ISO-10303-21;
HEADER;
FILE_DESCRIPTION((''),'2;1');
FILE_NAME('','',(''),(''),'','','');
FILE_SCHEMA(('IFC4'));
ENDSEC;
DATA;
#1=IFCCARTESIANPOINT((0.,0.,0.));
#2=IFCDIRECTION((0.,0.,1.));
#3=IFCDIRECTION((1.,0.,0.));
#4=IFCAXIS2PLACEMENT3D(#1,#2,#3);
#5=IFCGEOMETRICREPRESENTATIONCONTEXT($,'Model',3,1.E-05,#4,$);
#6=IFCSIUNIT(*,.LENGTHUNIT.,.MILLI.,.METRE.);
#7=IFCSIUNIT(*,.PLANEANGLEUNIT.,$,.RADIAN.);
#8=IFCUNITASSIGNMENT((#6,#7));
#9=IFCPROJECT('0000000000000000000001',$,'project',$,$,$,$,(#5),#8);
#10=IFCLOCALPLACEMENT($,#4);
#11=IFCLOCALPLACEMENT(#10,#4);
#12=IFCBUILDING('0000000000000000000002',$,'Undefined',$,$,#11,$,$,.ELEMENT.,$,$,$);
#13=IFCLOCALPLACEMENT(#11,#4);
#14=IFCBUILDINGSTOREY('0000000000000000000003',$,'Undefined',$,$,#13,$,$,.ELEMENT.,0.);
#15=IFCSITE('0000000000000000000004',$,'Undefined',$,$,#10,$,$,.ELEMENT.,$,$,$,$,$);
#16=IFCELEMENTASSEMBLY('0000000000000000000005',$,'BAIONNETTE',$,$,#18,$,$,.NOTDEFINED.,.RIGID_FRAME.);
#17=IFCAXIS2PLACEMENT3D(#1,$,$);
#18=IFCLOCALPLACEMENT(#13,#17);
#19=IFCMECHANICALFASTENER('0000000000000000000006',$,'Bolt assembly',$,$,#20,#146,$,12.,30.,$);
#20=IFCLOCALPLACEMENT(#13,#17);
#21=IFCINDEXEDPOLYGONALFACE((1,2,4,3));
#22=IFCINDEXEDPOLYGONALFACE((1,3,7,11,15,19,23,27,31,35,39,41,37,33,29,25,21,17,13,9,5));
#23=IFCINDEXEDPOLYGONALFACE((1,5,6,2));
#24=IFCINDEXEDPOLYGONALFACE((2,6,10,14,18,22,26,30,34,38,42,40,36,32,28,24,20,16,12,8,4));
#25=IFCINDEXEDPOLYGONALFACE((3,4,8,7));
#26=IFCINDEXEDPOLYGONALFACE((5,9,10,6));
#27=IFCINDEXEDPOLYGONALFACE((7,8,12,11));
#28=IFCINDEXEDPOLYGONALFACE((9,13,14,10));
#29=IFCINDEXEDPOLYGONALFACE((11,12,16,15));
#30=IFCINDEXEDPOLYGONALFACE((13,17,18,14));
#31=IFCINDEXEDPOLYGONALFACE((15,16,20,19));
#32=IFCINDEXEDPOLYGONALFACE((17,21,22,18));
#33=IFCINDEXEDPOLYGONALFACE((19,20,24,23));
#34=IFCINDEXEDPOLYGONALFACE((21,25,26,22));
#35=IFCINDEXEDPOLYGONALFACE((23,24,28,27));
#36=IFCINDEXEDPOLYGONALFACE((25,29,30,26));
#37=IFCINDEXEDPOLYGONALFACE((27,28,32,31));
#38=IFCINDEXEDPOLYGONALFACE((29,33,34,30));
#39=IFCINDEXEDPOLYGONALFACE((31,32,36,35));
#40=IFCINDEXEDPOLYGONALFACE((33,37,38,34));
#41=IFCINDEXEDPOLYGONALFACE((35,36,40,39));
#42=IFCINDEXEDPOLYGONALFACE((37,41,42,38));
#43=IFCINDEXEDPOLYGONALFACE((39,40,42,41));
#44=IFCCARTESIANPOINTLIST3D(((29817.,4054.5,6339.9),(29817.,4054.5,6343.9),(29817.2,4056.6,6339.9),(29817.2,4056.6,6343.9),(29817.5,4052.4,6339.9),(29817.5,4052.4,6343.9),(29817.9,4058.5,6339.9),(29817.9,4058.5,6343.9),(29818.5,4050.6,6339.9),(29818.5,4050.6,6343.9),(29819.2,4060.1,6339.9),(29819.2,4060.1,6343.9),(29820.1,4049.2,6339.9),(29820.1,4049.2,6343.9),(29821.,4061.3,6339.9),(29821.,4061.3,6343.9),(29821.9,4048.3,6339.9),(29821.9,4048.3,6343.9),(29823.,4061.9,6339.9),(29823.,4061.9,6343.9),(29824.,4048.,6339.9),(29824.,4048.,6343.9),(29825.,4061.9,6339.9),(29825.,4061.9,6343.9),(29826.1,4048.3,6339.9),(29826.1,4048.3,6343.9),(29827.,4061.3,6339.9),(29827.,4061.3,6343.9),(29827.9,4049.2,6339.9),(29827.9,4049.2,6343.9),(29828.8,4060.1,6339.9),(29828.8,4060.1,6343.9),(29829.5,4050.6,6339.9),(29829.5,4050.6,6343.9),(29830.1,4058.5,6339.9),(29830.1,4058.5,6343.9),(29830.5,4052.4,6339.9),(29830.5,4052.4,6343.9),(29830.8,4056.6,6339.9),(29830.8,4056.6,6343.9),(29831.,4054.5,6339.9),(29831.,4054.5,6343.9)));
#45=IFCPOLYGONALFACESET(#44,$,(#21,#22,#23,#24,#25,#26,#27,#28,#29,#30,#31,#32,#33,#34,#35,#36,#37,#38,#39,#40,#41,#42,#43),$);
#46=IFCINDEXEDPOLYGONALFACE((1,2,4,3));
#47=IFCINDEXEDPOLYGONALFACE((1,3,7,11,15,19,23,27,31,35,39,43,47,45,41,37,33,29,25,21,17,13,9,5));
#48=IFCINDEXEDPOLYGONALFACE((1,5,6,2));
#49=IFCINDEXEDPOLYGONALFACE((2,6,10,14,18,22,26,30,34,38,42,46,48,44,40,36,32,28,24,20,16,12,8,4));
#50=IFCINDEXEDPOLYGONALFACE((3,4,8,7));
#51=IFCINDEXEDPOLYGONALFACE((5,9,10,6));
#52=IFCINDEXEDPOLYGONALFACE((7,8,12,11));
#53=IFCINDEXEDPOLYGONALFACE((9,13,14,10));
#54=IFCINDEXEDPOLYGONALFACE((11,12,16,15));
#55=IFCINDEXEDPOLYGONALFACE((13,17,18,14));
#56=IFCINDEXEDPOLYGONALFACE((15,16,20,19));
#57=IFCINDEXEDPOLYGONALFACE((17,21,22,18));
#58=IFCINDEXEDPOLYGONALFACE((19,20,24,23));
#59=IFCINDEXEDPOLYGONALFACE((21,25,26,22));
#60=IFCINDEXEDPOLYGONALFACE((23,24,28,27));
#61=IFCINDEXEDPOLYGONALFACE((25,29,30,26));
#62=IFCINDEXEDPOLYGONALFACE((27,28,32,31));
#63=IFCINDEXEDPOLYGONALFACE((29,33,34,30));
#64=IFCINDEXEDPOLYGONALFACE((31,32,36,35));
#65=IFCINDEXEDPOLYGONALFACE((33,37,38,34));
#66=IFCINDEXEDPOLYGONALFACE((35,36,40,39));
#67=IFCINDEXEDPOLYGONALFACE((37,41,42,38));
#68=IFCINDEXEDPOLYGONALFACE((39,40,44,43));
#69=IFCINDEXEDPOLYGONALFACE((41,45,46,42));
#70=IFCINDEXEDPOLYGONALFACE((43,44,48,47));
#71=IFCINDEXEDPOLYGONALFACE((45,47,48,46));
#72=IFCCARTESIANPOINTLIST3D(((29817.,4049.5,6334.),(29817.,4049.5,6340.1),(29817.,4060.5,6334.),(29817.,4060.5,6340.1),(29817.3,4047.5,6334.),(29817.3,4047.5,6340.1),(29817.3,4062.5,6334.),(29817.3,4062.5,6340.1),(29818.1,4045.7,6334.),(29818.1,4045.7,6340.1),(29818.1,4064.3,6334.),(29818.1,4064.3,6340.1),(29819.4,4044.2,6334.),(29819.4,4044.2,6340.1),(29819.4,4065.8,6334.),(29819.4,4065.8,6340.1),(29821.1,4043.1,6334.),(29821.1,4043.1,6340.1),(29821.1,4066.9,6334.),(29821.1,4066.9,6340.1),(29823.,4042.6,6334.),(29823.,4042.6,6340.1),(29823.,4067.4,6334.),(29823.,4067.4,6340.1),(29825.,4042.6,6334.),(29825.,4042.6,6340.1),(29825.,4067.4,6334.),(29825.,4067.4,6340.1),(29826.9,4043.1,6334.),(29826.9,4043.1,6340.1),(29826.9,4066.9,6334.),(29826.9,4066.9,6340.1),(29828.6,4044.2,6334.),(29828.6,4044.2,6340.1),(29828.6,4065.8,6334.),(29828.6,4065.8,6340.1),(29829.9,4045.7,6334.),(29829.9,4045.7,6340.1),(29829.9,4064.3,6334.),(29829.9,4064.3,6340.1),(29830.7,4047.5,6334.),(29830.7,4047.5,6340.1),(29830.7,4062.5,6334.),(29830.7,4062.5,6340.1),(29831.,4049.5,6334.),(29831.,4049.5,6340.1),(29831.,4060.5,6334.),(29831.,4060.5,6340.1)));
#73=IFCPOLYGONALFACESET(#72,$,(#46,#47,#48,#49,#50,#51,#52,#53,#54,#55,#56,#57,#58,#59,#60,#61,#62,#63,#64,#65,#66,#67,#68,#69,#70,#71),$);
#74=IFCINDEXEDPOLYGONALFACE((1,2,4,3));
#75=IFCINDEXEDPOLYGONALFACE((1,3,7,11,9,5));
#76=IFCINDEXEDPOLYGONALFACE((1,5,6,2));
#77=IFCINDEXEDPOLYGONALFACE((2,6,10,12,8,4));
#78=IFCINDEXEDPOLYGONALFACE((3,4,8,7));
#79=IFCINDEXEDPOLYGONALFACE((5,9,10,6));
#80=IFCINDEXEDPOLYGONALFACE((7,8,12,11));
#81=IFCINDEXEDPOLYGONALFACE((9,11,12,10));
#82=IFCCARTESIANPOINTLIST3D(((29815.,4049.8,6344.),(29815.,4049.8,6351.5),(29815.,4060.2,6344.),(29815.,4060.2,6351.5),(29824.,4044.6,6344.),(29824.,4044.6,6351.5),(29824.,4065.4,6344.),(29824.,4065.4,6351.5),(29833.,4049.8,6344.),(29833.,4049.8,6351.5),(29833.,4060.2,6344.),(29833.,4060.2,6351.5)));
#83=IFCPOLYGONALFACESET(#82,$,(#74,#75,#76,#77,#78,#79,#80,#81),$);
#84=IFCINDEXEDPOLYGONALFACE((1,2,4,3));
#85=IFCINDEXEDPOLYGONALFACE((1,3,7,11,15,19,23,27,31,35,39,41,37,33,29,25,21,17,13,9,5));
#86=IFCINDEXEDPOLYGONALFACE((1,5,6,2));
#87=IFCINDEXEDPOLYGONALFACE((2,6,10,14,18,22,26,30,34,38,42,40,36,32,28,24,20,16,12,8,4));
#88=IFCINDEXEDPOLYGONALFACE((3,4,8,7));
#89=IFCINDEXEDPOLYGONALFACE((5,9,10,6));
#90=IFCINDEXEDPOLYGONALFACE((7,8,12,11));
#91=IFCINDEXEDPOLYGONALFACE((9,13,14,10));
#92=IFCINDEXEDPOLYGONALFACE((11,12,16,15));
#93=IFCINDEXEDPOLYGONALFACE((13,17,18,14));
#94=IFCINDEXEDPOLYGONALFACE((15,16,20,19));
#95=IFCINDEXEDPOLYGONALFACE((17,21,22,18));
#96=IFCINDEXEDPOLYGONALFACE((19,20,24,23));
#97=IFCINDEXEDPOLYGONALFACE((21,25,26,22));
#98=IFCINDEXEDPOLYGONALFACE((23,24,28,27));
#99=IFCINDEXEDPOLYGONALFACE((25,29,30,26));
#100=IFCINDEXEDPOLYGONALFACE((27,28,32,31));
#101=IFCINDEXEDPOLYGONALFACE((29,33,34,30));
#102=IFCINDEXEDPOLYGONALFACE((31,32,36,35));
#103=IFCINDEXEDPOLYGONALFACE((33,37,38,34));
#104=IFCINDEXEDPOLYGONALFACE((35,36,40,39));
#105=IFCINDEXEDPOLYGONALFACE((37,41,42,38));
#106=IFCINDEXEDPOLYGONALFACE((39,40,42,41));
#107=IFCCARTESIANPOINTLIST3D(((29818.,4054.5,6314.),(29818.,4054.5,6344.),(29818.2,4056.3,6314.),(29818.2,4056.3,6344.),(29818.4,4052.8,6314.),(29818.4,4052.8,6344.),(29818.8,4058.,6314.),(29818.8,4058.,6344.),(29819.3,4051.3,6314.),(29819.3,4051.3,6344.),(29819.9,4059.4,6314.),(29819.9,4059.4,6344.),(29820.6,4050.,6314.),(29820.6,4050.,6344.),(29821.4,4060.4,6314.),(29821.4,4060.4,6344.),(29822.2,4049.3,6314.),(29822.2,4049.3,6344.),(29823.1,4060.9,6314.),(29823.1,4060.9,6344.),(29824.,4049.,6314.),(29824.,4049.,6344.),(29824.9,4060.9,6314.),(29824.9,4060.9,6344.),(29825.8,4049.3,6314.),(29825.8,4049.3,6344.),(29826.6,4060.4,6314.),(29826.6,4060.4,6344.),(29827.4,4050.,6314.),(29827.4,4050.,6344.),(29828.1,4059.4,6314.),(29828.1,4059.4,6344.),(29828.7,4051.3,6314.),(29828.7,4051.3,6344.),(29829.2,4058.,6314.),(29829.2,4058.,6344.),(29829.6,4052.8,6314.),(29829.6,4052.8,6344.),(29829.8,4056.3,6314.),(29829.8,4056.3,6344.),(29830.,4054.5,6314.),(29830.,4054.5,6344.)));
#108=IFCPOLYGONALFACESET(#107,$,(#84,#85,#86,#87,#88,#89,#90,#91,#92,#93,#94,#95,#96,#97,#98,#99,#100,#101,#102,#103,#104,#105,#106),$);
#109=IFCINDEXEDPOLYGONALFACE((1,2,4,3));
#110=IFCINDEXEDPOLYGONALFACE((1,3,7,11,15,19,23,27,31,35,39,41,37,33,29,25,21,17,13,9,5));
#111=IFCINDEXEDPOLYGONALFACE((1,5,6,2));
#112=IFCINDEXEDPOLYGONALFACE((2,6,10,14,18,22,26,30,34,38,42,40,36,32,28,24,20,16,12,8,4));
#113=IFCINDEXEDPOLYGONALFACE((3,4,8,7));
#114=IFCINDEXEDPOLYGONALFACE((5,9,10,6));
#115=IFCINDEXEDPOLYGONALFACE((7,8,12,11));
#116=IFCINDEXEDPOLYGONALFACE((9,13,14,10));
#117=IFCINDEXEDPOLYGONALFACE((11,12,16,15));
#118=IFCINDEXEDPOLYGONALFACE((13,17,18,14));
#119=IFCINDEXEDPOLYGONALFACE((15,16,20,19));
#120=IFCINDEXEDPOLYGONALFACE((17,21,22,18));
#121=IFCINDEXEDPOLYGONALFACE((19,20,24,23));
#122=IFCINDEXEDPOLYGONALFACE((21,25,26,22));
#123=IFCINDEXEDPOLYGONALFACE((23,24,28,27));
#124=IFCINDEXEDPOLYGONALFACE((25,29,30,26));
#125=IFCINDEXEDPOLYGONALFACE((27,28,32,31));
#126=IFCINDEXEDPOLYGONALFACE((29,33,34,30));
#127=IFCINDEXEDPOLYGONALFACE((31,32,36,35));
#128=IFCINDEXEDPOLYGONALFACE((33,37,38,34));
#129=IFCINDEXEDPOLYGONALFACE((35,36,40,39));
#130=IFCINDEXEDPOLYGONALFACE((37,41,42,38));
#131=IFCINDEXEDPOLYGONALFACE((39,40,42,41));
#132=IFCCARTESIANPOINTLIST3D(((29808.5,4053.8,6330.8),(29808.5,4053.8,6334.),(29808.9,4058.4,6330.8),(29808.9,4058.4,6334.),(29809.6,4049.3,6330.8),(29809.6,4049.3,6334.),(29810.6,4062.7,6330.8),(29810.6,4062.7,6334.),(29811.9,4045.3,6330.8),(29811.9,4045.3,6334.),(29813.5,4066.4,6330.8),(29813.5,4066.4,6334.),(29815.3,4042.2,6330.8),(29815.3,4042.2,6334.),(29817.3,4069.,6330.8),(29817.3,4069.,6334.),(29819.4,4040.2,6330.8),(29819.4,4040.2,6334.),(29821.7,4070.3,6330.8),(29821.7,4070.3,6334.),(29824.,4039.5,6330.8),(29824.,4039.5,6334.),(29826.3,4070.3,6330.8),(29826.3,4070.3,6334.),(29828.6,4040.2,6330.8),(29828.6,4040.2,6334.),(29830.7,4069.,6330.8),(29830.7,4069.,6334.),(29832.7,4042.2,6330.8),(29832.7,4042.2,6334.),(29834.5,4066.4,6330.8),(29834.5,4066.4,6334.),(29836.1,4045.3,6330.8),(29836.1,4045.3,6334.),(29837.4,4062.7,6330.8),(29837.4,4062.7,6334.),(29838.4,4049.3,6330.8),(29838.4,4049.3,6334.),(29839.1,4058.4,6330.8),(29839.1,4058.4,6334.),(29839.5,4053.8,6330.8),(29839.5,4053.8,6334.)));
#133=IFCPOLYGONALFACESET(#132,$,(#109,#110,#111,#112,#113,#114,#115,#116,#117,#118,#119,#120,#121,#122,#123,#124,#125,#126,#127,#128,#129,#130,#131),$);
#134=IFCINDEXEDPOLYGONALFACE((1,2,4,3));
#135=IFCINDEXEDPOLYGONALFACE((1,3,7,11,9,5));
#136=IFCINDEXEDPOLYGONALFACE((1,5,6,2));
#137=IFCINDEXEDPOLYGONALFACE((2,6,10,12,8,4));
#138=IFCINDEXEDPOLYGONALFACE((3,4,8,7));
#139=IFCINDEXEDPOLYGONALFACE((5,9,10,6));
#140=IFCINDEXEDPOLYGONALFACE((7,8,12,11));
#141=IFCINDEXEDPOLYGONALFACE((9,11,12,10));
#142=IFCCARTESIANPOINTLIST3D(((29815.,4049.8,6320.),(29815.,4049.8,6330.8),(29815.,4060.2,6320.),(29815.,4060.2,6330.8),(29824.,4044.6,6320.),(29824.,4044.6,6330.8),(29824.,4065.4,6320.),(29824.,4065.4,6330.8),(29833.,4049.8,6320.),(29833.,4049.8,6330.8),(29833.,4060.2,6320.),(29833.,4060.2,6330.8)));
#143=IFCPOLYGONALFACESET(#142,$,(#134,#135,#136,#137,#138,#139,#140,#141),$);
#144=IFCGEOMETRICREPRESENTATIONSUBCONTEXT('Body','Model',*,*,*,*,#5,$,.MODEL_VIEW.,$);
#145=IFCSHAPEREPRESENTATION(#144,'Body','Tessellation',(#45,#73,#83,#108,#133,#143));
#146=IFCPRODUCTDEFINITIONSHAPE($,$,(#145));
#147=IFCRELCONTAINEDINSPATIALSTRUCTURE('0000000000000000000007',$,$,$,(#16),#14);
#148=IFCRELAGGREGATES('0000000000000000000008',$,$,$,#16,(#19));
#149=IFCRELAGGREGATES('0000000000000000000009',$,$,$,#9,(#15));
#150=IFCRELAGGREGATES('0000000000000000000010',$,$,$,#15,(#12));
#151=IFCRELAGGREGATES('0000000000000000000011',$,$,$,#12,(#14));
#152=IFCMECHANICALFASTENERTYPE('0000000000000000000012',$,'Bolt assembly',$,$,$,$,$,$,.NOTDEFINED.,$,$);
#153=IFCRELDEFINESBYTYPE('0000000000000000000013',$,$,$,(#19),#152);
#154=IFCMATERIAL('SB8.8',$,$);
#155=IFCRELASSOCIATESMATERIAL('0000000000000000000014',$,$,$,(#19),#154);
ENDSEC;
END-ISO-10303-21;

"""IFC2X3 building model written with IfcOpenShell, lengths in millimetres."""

from ifc_helpers import new_model, si_unit, frame, frame_2d, origin_with_axes, origin_2d_with_axis, place, context, subcontext, project, spatial, polyline, circle_curve, parameter, trimmed, segment, composite_curve, circle, outline, extrude, source, transform, mapped, material, type_object, element, aggregate, save


model = new_model("IFC2X3")

# Units and contexts
model_context = context("Model", 3, precision=1e-05, world=origin_with_axes())
body_context = subcontext(model_context, "Body", "Model", "MODEL_VIEW")
ifc_project = project(units=[si_unit("LENGTHUNIT", "METRE", prefix="MILLI"), si_unit("PLANEANGLEUNIT", "RADIAN")], contexts=[model_context])

# Site, building, storey
site_placement = place(None, origin_with_axes())
site = spatial("IfcSite", under=ifc_project, at=site_placement, Name="Undefined", CompositionType="ELEMENT")
building_placement = place(site_placement, origin_with_axes())
building = spatial("IfcBuilding", under=site, at=building_placement, Name="Undefined", CompositionType="ELEMENT")
storey_placement = place(building_placement, origin_with_axes())
storey = spatial("IfcBuildingStorey", under=building, at=storey_placement, Name="Undefined", CompositionType="ELEMENT", Elevation=0.0)

# Element assembly
assembly_1_placement = place(storey_placement, origin_with_axes())
assembly_1 = element("IfcElementAssembly", 1, at=assembly_1_placement, inside=storey, Name="BAIONNETTE", AssemblyPlace="NOTDEFINED", PredefinedType="RIGID_FRAME")

# Shared definitions
ifc_material_1 = material(Name="SB8.8")
mechanical_fastener_type = type_object("IfcMechanicalFastenerType", Name="Bolt assembly")

# Mechanical fastener
shared_shape_1 = source(origin_with_axes(), body_context, "Body", "SweptSolid", [
    extrude(circle(Radius=7.0, at=origin_2d_with_axis()), frame((0.0, -3.9, 0.0), z_axis=(0.0, 1.0, 0.0), x_axis=(1.0, 0.0, 0.0)), (0.0, 0.0, 1.0), 4.0),
    extrude(outline(composite_curve([segment(polyline([(-5.5, 7.0), (5.5, 7.0)]), True, "CONTINUOUS"), segment(trimmed(circle_curve(frame_2d((5.5, 0.0), x_axis=(0.0, 1.0)), 7.0), [parameter(0.0)], [parameter(3.141593)], False, "PARAMETER"), True, "CONTINUOUS"), segment(polyline([(5.5, -7.0), (-5.5, -7.0)]), True, "CONTINUOUS"), segment(trimmed(circle_curve(frame_2d((-5.5, 0.0), x_axis=(0.0, -1.0)), 7.0), [parameter(0.0)], [parameter(3.141593)], False, "PARAMETER"), True, "DISCONTINUOUS")], self_intersect=False)), frame((0.0, -0.1, 0.0), z_axis=(0.0, 1.0, 0.0), x_axis=(1.0, 0.0, 0.0)), (0.0, 0.0, 1.0), 6.1),
    extrude(outline(polyline([(10.4, 0.0), (5.2, 9.0), (-5.2, 9.0), (-10.4, 0.0), (-5.2, -9.0), (5.2, -9.0), (10.4, 0.0)])), frame((0.0, -11.5, 0.0), z_axis=(0.0, 1.0, 0.0), x_axis=(1.0, 0.0, 0.0)), (0.0, 0.0, 1.0), 7.5),
    extrude(circle(Radius=6.0, at=origin_2d_with_axis()), frame((0.0, -4.0, 0.0), z_axis=(0.0, 1.0, 0.0), x_axis=(1.0, 0.0, 0.0)), (0.0, 0.0, 1.0), 30.0),
    extrude(circle(Radius=15.5, at=origin_2d_with_axis()), frame((0.0, 6.0, 0.0), z_axis=(0.0, 1.0, 0.0), x_axis=(1.0, 0.0, 0.0)), (0.0, 0.0, 1.0), 3.2),
    extrude(outline(polyline([(10.4, 0.0), (5.2, 9.0), (-5.2, 9.0), (-10.4, 0.0), (-5.2, -9.0), (5.2, -9.0), (10.4, 0.0)])), frame((0.0, 9.2, 0.0), z_axis=(0.0, 1.0, 0.0), x_axis=(1.0, 0.0, 0.0)), (0.0, 0.0, 1.0), 10.8),
])
mechanical_fastener_1_placement = place(assembly_1_placement, frame((29824.0, 4055.0, 6340.0), z_axis=(1.0, 0.0, 0.0), x_axis=(0.0, -1.0, 0.0)))
mechanical_fastener_1 = element("IfcMechanicalFastener", 2, at=mechanical_fastener_1_placement, type_object=mechanical_fastener_type, material=ifc_material_1, Name="Bolt assembly", NominalDiameter=12.0, NominalLength=30.0, context=body_context, shape_type="MappedRepresentation", body=[
    mapped(shared_shape_1, transform((0.0, 0.0, 0.0))),
])
aggregate(assembly_1, [mechanical_fastener_1])

save(model, "model.ifc")
